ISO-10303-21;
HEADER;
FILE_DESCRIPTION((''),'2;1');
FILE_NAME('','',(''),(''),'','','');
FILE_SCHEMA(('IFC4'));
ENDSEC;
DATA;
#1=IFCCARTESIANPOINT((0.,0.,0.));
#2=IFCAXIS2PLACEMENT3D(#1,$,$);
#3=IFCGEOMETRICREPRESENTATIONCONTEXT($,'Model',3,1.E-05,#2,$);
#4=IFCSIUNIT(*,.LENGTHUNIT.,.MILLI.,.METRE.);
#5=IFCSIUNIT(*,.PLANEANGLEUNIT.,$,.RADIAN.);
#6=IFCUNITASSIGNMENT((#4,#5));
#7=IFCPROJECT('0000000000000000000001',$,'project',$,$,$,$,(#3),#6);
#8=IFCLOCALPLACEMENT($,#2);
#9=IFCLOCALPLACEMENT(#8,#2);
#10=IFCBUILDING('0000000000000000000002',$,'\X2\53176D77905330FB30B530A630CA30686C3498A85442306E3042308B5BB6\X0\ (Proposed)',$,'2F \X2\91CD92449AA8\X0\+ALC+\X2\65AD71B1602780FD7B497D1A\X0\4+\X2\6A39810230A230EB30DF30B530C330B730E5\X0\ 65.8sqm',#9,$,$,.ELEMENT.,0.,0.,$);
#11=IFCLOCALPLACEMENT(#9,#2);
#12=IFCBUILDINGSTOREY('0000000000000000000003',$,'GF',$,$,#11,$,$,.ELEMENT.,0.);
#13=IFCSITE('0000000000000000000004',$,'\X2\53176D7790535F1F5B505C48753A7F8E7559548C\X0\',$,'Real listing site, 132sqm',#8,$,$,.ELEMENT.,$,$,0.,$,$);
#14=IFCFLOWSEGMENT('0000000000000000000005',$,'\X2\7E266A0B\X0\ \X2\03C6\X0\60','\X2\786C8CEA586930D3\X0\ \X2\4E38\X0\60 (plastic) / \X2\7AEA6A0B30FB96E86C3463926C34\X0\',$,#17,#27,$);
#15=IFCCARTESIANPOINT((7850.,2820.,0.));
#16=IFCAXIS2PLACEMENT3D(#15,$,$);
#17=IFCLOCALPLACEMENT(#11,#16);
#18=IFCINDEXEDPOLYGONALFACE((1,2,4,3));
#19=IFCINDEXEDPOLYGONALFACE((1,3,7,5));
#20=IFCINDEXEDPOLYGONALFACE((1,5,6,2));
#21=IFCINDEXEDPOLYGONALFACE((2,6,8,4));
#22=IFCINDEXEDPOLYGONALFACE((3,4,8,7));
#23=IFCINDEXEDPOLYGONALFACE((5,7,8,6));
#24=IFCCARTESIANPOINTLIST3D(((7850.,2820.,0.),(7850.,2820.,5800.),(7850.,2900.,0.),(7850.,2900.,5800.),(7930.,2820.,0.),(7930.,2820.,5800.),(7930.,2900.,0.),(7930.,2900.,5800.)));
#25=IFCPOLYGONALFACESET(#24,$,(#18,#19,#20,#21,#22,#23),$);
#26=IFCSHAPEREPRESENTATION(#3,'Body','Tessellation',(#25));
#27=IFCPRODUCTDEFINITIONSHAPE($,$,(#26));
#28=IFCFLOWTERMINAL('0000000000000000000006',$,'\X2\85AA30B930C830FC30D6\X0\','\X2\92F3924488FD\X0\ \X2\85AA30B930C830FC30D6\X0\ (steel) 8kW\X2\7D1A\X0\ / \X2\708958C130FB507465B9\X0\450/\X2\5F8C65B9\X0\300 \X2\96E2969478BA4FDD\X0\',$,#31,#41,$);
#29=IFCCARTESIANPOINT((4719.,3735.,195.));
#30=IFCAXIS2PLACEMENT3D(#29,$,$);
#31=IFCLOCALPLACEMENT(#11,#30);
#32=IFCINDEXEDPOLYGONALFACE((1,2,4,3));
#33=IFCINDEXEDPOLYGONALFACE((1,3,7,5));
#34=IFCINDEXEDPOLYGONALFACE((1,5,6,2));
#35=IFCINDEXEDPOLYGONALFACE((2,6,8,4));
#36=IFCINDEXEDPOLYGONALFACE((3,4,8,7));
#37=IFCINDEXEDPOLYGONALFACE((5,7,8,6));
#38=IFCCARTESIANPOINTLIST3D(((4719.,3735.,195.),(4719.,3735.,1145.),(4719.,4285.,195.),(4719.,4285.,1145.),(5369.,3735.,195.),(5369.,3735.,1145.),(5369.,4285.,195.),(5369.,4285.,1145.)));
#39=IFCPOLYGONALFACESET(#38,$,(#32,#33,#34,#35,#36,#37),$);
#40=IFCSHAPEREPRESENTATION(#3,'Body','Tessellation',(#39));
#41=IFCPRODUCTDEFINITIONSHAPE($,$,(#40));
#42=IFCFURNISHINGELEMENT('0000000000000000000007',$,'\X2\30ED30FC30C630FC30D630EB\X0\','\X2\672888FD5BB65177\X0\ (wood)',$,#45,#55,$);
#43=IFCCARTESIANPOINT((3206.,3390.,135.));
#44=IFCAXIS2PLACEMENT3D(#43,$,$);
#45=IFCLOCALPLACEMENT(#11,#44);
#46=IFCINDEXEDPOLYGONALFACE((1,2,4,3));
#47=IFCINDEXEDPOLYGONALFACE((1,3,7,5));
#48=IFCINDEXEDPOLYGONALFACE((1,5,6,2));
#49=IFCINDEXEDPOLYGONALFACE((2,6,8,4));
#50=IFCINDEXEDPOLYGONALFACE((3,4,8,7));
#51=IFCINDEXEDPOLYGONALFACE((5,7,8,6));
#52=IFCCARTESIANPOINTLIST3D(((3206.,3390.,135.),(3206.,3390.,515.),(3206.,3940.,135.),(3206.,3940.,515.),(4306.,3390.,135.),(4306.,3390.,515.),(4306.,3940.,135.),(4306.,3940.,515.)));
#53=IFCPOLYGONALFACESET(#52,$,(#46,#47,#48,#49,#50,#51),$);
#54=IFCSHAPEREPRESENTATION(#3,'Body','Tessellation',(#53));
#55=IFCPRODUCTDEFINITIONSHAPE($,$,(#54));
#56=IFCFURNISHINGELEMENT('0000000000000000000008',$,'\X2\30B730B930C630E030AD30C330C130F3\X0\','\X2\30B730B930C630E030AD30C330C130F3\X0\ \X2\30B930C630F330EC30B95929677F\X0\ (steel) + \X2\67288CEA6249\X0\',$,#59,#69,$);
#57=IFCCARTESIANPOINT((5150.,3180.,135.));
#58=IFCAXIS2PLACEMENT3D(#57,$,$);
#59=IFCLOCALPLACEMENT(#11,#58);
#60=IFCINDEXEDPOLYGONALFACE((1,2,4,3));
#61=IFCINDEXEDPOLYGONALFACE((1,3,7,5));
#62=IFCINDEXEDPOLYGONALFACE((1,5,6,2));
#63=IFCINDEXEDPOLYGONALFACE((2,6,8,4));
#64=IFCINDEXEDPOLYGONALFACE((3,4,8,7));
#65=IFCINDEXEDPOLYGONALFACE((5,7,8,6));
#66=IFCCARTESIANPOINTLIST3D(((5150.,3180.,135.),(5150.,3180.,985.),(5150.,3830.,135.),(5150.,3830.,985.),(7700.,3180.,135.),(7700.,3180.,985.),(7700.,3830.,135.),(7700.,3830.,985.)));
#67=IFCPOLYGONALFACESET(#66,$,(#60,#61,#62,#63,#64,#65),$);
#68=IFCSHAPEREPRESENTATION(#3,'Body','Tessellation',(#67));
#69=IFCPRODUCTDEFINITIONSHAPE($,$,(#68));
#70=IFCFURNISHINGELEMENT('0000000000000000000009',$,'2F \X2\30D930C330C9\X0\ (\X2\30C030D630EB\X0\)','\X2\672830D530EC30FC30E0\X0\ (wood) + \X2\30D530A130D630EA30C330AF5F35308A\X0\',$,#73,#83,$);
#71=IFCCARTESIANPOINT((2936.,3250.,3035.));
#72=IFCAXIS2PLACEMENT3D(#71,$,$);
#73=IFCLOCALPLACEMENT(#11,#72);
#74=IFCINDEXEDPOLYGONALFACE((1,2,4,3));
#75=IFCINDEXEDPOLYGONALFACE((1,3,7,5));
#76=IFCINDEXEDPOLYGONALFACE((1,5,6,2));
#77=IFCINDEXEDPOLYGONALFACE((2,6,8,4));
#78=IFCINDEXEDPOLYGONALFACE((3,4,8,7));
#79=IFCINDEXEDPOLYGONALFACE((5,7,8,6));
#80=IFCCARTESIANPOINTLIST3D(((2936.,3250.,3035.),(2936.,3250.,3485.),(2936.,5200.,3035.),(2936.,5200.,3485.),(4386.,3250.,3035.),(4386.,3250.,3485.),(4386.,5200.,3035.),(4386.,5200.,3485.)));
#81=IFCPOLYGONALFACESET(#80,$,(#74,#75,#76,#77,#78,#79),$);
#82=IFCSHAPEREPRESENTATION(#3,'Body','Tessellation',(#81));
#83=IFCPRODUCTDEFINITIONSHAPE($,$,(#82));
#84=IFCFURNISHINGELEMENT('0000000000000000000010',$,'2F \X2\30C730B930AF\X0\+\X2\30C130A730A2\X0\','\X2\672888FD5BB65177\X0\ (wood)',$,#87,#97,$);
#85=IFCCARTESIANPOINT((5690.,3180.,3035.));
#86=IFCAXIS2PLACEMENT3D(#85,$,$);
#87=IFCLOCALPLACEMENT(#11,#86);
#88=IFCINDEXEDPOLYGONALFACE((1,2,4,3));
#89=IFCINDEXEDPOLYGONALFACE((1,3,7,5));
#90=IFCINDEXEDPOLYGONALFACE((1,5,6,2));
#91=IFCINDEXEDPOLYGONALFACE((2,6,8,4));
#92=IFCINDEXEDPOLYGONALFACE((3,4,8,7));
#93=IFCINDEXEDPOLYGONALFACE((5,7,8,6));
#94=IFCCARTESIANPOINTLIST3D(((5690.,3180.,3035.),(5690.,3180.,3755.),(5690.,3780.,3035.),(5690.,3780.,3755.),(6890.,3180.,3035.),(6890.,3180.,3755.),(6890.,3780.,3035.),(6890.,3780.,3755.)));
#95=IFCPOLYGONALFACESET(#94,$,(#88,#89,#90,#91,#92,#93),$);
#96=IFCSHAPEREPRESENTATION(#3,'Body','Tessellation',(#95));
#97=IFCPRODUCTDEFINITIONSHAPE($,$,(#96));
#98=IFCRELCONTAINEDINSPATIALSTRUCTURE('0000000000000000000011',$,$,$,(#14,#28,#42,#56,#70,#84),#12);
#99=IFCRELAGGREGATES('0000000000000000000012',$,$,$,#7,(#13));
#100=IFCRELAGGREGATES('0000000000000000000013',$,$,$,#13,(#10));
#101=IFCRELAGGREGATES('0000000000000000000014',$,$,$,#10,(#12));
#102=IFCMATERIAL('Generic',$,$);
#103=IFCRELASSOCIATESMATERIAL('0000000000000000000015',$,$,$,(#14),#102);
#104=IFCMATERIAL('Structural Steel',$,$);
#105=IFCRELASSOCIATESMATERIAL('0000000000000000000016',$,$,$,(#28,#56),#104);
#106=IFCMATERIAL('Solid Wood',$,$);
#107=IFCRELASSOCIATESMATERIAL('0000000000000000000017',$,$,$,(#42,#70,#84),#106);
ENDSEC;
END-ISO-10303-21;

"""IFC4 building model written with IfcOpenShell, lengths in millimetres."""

from ifc_helpers import new_model, si_unit, frame, frame_2d, origin, place, context, project, spatial, rectangle, extrude, material, element, save


model = new_model("IFC4")

# Units and contexts
model_context = context("Model", 3, precision=1e-05, world=origin())
ifc_project = project(units=[si_unit("LENGTHUNIT", "METRE", prefix="MILLI"), si_unit("PLANEANGLEUNIT", "RADIAN")], contexts=[model_context])

# Site, building, storey
site_placement = place(None, origin())
site = spatial("IfcSite", under=ifc_project, at=site_placement, Name="北海道弟子屈町美留和", ObjectType="Real listing site, 132sqm", CompositionType="ELEMENT", RefElevation=0.0)
building_placement = place(site_placement, origin())
building = spatial("IfcBuilding", under=site, at=building_placement, Name="北海道・サウナと水風呂のある家 (Proposed)", ObjectType="2F 重鉄骨+ALC+断熱性能等級4+樹脂アルミサッシュ 65.8sqm", CompositionType="ELEMENT", ElevationOfRefHeight=0.0, ElevationOfTerrain=0.0)
storey_placement = place(building_placement, origin())
storey = spatial("IfcBuildingStorey", under=building, at=storey_placement, Name="GF", CompositionType="ELEMENT", Elevation=0.0)

# Shared definitions
ifc_material_1 = material(Name="Solid Wood")

# Shared definitions
ifc_material_2 = material(Name="Structural Steel")

# Shared definitions
ifc_material_3 = material(Name="Generic")

# Flow segment
flow_segment_placement = place(storey_placement, frame((7850.0, 2820.0, 0.0)))
element("IfcFlowSegment", 1, at=flow_segment_placement, inside=storey, material=ifc_material_3, Name="縦樋 φ60", Description="硬質塩ビ 丸60 (plastic) / 竪樋・雨水排水", context=model_context, shape_type="SweptSolid", body=[
    extrude(rectangle(XDim=80.0, YDim=80.0, at=frame_2d((40.0, 40.0))), frame((7850.0, 2820.0, 0.0)), (0.0, 0.0, 1.0), 5800.0),
])

# Flow terminal
flow_terminal_1_placement = place(storey_placement, frame((4719.0, 3735.0, 195.0)))
element("IfcFlowTerminal", 2, at=flow_terminal_1_placement, inside=storey, material=ifc_material_2, Name="薪ストーブ", Description="鋳鉄製 薪ストーブ (steel) 8kW級 / 炉壁・側方450/後方300 離隔確保", context=model_context, shape_type="SweptSolid", body=[
    extrude(rectangle(XDim=650.0, YDim=550.0, at=frame_2d((325.0, 275.0))), frame((4719.0, 3735.0, 195.0)), (0.0, 0.0, 1.0), 950.0),
])

# Furnishing elements
furnishing_1_placement = place(storey_placement, frame((3206.0, 3390.0, 135.0)))
element("IfcFurnishingElement", 3, at=furnishing_1_placement, inside=storey, material=ifc_material_1, Name="ローテーブル", Description="木製家具 (wood)", context=model_context, shape_type="SweptSolid", body=[
    extrude(rectangle(XDim=1100.0, YDim=550.0, at=frame_2d((550.0, 275.0))), frame((3206.0, 3390.0, 135.0)), (0.0, 0.0, 1.0), 380.0),
])
furnishing_2_placement = place(storey_placement, frame((5150.0, 3180.0, 135.0)))
element("IfcFurnishingElement", 4, at=furnishing_2_placement, inside=storey, material=ifc_material_2, Name="システムキッチン", Description="システムキッチン ステンレス天板 (steel) + 木質扉", context=model_context, shape_type="SweptSolid", body=[
    extrude(rectangle(XDim=2550.0, YDim=650.0, at=frame_2d((1275.0, 325.0))), frame((5150.0, 3180.0, 135.0)), (0.0, 0.0, 1.0), 850.0),
])
furnishing_3_placement = place(storey_placement, frame((2936.0, 3250.0, 3035.0)))
element("IfcFurnishingElement", 5, at=furnishing_3_placement, inside=storey, material=ifc_material_1, Name="2F ベッド (ダブル)", Description="木フレーム (wood) + ファブリック張り", context=model_context, shape_type="SweptSolid", body=[
    extrude(rectangle(XDim=1450.0, YDim=1950.0, at=frame_2d((725.0, 975.0))), frame((2936.0, 3250.0, 3035.0)), (0.0, 0.0, 1.0), 450.0),
])
furnishing_4_placement = place(storey_placement, frame((5690.0, 3180.0, 3035.0)))
element("IfcFurnishingElement", 6, at=furnishing_4_placement, inside=storey, material=ifc_material_1, Name="2F デスク+チェア", Description="木製家具 (wood)", context=model_context, shape_type="SweptSolid", body=[
    extrude(rectangle(XDim=1200.0, YDim=600.0, at=frame_2d((600.0, 300.0))), frame((5690.0, 3180.0, 3035.0)), (0.0, 0.0, 1.0), 720.0),
])

save(model, "model.ifc")
